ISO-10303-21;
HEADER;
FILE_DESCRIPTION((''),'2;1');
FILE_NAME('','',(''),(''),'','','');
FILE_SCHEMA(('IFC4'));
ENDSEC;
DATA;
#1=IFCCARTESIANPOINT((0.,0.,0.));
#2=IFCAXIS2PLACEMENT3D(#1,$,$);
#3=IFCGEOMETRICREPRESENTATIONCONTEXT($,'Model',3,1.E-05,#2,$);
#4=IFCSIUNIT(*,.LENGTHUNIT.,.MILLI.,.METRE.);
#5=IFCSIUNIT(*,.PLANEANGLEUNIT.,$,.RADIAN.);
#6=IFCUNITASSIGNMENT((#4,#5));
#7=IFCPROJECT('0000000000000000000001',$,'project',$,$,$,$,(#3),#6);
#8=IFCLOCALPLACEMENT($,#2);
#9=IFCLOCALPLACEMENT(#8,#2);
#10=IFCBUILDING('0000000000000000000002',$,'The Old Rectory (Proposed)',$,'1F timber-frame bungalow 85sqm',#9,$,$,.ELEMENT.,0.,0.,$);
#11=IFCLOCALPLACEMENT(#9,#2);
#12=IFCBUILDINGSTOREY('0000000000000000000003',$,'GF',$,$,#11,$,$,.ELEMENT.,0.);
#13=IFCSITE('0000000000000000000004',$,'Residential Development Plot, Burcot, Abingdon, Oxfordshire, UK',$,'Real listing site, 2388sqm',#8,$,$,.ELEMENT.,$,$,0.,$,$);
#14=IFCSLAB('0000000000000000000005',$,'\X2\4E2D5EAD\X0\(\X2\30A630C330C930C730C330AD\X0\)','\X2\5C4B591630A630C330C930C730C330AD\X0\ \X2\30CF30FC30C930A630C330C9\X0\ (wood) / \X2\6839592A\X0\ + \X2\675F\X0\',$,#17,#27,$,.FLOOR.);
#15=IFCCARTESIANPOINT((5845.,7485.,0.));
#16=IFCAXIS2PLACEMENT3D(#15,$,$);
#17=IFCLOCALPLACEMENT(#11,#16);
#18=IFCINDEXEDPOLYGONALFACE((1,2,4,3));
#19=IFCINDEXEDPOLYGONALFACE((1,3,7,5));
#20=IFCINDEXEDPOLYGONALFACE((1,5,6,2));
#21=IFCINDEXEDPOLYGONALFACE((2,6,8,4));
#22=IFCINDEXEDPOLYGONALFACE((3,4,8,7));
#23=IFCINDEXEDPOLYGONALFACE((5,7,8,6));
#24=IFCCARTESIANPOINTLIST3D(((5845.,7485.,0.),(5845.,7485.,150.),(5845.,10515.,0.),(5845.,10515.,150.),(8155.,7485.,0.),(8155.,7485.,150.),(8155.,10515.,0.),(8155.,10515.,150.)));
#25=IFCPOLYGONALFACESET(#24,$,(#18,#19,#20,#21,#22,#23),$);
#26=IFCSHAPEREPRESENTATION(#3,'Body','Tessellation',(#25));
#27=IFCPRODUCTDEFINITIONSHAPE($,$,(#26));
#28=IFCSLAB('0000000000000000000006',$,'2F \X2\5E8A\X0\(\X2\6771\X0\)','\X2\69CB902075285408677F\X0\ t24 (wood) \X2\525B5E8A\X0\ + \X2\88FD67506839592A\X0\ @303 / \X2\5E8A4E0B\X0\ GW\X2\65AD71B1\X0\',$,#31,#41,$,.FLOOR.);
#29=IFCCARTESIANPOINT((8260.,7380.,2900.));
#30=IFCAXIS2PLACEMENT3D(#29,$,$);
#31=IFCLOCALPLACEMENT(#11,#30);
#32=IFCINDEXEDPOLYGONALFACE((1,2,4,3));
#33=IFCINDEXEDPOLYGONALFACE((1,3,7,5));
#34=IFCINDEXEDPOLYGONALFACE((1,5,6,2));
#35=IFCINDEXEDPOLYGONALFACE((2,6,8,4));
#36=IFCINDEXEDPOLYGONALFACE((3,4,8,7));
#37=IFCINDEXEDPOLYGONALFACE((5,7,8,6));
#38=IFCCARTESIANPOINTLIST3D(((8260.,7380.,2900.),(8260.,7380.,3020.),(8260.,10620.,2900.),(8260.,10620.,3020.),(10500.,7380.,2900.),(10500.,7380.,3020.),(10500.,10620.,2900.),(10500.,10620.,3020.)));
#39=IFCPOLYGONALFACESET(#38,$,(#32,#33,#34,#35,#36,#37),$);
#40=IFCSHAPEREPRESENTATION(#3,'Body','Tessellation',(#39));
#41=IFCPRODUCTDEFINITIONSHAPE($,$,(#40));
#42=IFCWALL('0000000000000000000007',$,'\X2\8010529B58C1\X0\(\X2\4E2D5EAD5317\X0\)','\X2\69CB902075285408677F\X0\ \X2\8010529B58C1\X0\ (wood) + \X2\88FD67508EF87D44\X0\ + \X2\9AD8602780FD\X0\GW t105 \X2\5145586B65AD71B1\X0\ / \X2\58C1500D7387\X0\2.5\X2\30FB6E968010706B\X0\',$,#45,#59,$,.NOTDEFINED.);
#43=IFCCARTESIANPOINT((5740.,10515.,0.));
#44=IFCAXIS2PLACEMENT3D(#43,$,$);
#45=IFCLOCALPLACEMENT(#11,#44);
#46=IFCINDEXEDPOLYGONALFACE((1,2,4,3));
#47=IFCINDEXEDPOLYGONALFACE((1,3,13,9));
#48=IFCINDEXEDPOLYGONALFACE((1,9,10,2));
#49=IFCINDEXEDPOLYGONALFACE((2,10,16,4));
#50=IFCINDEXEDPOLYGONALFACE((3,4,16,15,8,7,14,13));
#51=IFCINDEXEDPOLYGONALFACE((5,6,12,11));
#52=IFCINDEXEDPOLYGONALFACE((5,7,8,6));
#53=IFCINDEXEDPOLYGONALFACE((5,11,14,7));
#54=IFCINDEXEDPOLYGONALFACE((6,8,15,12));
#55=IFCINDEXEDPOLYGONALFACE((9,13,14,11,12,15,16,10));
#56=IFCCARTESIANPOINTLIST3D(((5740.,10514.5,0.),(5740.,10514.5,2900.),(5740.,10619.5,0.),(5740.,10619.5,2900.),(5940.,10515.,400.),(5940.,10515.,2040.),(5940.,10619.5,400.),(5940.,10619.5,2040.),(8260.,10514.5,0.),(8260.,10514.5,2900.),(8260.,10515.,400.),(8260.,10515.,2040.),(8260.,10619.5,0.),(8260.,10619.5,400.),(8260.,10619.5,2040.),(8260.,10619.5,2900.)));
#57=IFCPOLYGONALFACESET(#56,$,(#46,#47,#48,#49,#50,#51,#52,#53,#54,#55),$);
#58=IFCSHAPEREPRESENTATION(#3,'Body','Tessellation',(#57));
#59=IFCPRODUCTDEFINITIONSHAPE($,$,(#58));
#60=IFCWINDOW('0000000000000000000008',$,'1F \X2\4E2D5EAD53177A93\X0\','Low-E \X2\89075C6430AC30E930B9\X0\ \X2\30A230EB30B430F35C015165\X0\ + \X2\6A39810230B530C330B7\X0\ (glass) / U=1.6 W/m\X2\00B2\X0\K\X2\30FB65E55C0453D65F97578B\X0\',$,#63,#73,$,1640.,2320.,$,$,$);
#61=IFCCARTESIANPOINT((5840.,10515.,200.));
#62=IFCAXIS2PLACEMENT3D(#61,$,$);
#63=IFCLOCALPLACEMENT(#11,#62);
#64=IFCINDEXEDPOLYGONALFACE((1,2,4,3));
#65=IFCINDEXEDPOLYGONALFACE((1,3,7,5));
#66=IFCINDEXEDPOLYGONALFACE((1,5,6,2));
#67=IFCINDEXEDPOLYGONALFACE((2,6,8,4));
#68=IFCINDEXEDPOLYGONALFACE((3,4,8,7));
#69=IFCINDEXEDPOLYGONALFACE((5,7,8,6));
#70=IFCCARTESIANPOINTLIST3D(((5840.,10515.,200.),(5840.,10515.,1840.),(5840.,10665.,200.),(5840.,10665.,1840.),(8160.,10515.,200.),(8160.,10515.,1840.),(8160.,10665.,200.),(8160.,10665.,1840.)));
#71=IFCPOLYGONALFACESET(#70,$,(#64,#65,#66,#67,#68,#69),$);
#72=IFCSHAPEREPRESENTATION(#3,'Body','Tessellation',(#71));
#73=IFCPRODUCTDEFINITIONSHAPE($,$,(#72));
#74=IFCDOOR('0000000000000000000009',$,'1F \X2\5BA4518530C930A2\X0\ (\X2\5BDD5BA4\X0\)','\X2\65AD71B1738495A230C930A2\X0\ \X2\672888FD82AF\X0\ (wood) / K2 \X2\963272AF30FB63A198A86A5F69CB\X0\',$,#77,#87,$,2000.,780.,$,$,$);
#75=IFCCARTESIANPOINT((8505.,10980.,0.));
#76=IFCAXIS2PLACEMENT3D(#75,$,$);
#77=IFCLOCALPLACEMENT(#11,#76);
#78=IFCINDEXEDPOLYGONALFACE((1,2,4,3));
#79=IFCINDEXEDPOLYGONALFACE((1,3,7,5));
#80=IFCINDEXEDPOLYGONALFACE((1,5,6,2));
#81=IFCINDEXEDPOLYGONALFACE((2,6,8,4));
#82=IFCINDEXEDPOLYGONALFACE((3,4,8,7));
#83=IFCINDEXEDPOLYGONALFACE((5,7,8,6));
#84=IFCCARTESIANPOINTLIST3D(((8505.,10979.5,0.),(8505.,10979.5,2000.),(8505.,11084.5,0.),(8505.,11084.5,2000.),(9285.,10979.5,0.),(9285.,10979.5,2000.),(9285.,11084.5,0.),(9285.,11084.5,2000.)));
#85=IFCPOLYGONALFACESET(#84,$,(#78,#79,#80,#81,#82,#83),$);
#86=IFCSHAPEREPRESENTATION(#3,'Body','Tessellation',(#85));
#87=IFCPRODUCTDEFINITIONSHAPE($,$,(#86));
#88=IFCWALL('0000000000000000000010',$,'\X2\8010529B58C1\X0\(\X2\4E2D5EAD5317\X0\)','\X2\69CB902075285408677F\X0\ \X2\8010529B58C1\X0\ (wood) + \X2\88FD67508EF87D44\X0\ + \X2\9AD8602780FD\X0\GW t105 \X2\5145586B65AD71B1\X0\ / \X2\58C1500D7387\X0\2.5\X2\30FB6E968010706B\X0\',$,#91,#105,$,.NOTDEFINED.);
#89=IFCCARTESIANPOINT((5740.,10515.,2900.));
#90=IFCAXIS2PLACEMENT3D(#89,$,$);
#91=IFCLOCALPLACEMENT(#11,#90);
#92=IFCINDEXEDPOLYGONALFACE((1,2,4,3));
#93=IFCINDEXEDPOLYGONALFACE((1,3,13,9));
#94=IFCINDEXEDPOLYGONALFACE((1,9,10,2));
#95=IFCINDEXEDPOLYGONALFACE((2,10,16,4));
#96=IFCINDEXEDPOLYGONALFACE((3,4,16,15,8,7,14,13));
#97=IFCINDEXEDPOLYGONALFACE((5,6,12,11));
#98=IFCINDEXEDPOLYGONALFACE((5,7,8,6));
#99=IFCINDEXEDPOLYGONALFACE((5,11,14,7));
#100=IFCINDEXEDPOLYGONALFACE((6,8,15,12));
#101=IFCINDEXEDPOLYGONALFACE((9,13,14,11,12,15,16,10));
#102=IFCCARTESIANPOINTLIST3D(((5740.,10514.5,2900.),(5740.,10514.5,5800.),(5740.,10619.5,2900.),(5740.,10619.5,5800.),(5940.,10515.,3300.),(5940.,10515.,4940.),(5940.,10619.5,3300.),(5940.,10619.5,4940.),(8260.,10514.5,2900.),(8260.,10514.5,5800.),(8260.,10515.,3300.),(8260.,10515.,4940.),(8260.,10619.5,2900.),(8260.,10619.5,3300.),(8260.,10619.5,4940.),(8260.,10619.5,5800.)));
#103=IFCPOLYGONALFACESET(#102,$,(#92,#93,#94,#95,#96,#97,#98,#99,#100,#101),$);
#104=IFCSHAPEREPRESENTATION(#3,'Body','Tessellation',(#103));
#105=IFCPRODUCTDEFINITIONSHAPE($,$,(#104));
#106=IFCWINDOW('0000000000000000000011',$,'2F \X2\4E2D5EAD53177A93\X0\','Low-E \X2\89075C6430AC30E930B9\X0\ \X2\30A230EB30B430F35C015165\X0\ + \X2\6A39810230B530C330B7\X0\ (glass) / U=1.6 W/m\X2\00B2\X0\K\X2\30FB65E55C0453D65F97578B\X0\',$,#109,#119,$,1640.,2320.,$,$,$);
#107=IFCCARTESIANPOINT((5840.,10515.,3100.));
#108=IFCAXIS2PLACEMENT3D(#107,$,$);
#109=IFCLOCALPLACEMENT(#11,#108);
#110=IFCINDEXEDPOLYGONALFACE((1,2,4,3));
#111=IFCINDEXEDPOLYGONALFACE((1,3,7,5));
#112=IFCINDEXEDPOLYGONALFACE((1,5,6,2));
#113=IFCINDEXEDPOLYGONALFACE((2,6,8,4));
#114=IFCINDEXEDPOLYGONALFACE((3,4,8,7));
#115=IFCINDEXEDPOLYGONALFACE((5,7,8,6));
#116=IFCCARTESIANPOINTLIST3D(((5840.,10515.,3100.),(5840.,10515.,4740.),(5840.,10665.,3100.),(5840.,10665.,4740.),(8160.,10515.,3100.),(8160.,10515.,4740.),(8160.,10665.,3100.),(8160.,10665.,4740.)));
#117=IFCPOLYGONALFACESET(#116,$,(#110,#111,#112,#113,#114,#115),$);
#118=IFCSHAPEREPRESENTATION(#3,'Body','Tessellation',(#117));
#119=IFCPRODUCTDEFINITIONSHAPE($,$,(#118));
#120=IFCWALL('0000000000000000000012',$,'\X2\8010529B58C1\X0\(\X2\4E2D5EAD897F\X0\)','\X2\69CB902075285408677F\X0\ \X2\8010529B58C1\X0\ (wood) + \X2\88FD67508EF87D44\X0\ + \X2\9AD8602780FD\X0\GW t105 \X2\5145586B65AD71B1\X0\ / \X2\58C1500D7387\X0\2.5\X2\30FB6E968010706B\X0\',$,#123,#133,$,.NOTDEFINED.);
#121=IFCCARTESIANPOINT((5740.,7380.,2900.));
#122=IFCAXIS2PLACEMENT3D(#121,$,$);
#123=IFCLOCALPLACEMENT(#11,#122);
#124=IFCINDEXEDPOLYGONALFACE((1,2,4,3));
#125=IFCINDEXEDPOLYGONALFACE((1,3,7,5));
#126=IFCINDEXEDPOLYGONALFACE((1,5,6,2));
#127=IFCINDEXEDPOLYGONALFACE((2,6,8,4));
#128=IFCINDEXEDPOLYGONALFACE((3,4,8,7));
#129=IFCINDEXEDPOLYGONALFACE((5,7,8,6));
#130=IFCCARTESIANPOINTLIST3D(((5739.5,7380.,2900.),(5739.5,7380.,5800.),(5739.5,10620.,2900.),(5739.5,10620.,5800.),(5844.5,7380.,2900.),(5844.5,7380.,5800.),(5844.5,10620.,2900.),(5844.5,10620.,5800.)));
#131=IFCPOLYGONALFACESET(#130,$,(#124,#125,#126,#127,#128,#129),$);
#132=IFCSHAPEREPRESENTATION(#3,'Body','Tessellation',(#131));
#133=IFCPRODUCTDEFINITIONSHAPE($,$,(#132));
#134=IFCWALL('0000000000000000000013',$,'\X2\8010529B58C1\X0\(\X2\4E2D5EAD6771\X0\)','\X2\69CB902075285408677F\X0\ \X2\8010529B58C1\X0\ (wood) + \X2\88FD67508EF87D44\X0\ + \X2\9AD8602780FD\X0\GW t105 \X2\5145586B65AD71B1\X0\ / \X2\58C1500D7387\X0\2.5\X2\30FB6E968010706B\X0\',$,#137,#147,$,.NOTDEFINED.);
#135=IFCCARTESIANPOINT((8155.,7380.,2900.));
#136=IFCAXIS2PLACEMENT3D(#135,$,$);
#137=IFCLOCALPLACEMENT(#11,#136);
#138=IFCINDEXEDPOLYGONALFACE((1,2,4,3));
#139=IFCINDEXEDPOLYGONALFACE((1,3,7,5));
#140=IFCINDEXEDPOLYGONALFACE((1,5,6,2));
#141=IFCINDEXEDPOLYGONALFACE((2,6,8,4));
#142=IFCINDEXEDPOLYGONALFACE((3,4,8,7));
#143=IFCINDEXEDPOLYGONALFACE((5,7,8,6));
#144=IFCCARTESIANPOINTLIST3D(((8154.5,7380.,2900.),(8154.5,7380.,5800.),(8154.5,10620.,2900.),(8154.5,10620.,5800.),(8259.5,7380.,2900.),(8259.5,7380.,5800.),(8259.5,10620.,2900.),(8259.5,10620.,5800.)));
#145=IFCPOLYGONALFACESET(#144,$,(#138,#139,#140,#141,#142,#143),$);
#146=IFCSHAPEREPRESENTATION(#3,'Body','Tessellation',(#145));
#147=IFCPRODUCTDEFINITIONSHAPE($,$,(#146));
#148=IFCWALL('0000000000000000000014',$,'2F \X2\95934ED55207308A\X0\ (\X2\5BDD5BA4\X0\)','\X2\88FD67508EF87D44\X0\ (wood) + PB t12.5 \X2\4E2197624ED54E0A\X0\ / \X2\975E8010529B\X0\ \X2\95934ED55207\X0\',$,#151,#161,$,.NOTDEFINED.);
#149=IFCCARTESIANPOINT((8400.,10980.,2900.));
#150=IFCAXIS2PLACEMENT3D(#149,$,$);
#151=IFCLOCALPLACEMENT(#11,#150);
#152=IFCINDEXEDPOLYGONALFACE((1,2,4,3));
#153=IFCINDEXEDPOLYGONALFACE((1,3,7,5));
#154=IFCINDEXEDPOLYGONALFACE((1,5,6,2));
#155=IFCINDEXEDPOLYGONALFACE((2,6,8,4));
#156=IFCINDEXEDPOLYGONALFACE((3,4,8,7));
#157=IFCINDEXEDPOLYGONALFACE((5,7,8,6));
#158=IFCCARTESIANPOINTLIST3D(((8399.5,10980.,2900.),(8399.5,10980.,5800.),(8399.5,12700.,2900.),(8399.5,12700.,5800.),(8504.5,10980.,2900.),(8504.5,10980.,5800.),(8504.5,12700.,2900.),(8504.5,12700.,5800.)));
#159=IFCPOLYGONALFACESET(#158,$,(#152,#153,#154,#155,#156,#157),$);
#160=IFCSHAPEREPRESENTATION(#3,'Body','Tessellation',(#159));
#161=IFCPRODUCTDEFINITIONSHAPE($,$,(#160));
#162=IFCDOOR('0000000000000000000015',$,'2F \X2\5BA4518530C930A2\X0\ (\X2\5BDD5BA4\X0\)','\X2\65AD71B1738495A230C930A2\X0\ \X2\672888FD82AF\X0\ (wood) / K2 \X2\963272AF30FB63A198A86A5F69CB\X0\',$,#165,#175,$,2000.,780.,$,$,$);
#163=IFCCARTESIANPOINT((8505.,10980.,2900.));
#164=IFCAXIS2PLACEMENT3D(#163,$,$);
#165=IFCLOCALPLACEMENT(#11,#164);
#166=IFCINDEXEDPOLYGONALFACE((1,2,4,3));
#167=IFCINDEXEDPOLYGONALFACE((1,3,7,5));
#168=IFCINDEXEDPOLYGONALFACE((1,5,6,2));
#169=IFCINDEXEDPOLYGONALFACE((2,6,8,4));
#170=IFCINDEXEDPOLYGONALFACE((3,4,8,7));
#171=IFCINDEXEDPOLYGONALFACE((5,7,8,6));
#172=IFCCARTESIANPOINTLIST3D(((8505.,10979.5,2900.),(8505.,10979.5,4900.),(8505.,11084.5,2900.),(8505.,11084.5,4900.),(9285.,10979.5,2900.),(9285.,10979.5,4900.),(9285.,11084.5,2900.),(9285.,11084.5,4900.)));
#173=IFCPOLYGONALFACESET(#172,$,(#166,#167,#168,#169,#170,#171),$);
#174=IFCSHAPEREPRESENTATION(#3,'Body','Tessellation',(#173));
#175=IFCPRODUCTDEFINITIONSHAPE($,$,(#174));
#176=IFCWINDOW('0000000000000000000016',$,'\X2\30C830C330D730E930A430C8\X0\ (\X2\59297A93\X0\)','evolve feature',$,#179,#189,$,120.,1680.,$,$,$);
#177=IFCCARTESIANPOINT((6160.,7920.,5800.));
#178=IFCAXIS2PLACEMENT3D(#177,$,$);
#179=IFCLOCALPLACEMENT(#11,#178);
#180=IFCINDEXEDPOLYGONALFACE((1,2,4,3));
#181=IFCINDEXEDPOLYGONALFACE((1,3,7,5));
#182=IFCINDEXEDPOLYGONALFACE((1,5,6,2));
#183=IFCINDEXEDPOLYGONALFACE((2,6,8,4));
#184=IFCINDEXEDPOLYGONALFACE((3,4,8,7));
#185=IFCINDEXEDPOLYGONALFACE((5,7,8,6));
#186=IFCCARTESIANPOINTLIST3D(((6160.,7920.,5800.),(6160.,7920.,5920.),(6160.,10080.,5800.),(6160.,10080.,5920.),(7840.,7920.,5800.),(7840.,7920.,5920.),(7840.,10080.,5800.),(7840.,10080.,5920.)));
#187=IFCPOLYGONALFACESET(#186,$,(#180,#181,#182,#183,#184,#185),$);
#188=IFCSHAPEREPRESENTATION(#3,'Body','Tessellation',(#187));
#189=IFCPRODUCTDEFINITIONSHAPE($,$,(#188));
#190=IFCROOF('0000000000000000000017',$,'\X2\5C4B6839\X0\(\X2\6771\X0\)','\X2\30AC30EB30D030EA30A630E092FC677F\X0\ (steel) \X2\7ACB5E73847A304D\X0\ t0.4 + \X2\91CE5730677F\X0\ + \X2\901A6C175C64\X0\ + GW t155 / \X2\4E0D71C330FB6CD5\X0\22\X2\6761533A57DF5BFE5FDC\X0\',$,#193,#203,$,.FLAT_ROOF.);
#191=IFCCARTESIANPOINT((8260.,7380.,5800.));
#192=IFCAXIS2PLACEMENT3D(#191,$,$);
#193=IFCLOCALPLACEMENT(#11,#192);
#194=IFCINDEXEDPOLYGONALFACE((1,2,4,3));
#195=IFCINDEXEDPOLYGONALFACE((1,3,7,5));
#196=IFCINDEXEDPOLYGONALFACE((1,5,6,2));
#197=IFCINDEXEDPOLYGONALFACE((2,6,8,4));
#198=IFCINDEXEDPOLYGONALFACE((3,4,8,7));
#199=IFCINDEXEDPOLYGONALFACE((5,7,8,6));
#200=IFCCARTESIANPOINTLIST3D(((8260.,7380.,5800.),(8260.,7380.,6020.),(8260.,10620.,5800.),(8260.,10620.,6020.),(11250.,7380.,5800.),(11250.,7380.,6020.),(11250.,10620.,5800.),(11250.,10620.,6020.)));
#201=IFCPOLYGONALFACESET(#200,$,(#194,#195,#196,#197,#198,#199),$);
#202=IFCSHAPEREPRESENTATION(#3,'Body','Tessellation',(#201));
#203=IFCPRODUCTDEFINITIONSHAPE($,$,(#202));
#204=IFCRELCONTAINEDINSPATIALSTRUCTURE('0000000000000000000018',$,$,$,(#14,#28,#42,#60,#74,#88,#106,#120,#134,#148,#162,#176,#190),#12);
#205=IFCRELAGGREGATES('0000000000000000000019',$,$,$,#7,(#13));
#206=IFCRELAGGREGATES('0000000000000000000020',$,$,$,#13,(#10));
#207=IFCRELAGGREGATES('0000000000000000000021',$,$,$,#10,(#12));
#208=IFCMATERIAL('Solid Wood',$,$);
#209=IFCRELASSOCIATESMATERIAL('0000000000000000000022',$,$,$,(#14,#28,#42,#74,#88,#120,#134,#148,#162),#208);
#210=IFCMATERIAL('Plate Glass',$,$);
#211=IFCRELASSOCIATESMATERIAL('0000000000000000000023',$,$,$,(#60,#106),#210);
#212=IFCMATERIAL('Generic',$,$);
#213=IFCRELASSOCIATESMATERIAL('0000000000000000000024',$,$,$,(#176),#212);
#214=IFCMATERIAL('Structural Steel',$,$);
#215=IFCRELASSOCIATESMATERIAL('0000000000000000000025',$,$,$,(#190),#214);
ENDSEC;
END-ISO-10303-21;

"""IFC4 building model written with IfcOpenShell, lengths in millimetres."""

from ifc_helpers import new_model, si_unit, frame, frame_2d, origin, place, context, project, spatial, rectangle, extrude, material, element, fill, save


model = new_model("IFC4")

# Units and contexts
model_context = context("Model", 3, precision=1e-05, world=origin())
ifc_project = project(units=[si_unit("LENGTHUNIT", "METRE", prefix="MILLI"), si_unit("PLANEANGLEUNIT", "RADIAN")], contexts=[model_context])

# Site, building, storey
site_placement = place(None, origin())
site = spatial("IfcSite", under=ifc_project, at=site_placement, Name="Residential Development Plot, Burcot, Abingdon, Oxfordshire, UK", ObjectType="Real listing site, 2388sqm", CompositionType="ELEMENT", RefElevation=0.0)
building_placement = place(site_placement, origin())
building = spatial("IfcBuilding", under=site, at=building_placement, Name="The Old Rectory (Proposed)", ObjectType="1F timber-frame bungalow 85sqm", CompositionType="ELEMENT", ElevationOfRefHeight=0.0, ElevationOfTerrain=0.0)
storey_placement = place(building_placement, origin())
storey = spatial("IfcBuildingStorey", under=building, at=storey_placement, Name="GF", CompositionType="ELEMENT", Elevation=0.0)

# Slabs
ifc_material_1 = material(Name="Solid Wood")
slab_1_placement = place(storey_placement, frame((5845.0, 7485.0, 0.0)))
element("IfcSlab", 1, at=slab_1_placement, inside=storey, material=ifc_material_1, Name="中庭(ウッドデッキ)", Description="屋外ウッドデッキ ハードウッド (wood) / 根太 + 束", PredefinedType="FLOOR", context=model_context, shape_type="SweptSolid", body=[
    extrude(rectangle(XDim=2310.0, YDim=3030.0, at=frame_2d((1155.0, 1515.0))), frame((5845.0, 7485.0, 0.0)), (0.0, 0.0, 1.0), 150.0),
])
slab_2_placement = place(storey_placement, frame((8260.0, 7380.0, 2900.0)))
element("IfcSlab", 2, at=slab_2_placement, inside=storey, material=ifc_material_1, Name="2F 床(東)", Description="構造用合板 t24 (wood) 剛床 + 製材根太 @303 / 床下 GW断熱", PredefinedType="FLOOR", context=model_context, shape_type="SweptSolid", body=[
    extrude(rectangle(XDim=2240.0, YDim=3240.0, at=frame_2d((1120.0, 1620.0))), frame((8260.0, 7380.0, 2900.0)), (0.0, 0.0, 1.0), 120.0),
])

# Wall, opening, window
wall_1_placement = place(storey_placement, frame((5740.0, 10515.0, 0.0)))
wall_1 = element("IfcWall", 3, at=wall_1_placement, inside=storey, material=ifc_material_1, Name="耐力壁(中庭北)", Description="構造用合板 耐力壁 (wood) + 製材軸組 + 高性能GW t105 充填断熱 / 壁倍率2.5・準耐火", PredefinedType="NOTDEFINED", context=model_context, shape_type="SweptSolid", body=[
    extrude(rectangle(XDim=2520.0, YDim=105.0, at=frame_2d((1260.0, 52.0))), frame((5740.0, 10515.0, 0.0)), (0.0, 0.0, 1.0), 2900.0),
])
opening_1_placement = place(storey_placement, frame((5840.0, 10515.0, 200.0)))
opening_1 = element("IfcOpeningElement", 4, at=opening_1_placement, cuts=wall_1, PredefinedType="NOTDEFINED", context=model_context, shape_type="SweptSolid", body=[
    extrude(rectangle(XDim=2320.0, YDim=150.0, at=frame_2d((1160.0, 75.0))), frame((5840.0, 10515.0, 200.0)), (0.0, 0.0, 1.0), 1640.0),
])
ifc_material_2 = material(Name="Plate Glass")
window_1_placement = place(storey_placement, frame((5840.0, 10515.0, 200.0)))
window_1 = element("IfcWindow", 5, at=window_1_placement, inside=storey, material=ifc_material_2, Name="1F 中庭北窓", Description="Low-E 複層ガラス アルゴン封入 + 樹脂サッシ (glass) / U=1.6 W/m²K・日射取得型", OverallHeight=1640.0, OverallWidth=2320.0, context=model_context, shape_type="SweptSolid", body=[
    extrude(rectangle(XDim=2320.0, YDim=150.0, at=frame_2d((1160.0, 75.0))), frame((5840.0, 10515.0, 200.0)), (0.0, 0.0, 1.0), 1640.0),
])
fill(opening_1, window_1)

# Door
door_1_placement = place(storey_placement, frame((8505.0, 10980.0, 0.0)))
element("IfcDoor", 6, at=door_1_placement, inside=storey, material=ifc_material_1, Name="1F 室内ドア (寝室)", Description="断熱玄関ドア 木製芯 (wood) / K2 防犯・採風機構", OverallHeight=2000.0, OverallWidth=780.0, context=model_context, shape_type="SweptSolid", body=[
    extrude(rectangle(XDim=780.0, YDim=105.0, at=frame_2d((390.0, 52.0))), frame((8505.0, 10980.0, 0.0)), (0.0, 0.0, 1.0), 2000.0),
])

# Wall, opening, window
wall_2_placement = place(storey_placement, frame((5740.0, 10515.0, 2900.0)))
wall_2 = element("IfcWall", 7, at=wall_2_placement, inside=storey, material=ifc_material_1, Name="耐力壁(中庭北)", Description="構造用合板 耐力壁 (wood) + 製材軸組 + 高性能GW t105 充填断熱 / 壁倍率2.5・準耐火", PredefinedType="NOTDEFINED", context=model_context, shape_type="SweptSolid", body=[
    extrude(rectangle(XDim=2520.0, YDim=105.0, at=frame_2d((1260.0, 52.0))), frame((5740.0, 10515.0, 2900.0)), (0.0, 0.0, 1.0), 2900.0),
])
opening_2_placement = place(storey_placement, frame((5840.0, 10515.0, 3100.0)))
opening_2 = element("IfcOpeningElement", 8, at=opening_2_placement, cuts=wall_2, PredefinedType="NOTDEFINED", context=model_context, shape_type="SweptSolid", body=[
    extrude(rectangle(XDim=2320.0, YDim=150.0, at=frame_2d((1160.0, 75.0))), frame((5840.0, 10515.0, 3100.0)), (0.0, 0.0, 1.0), 1640.0),
])
window_2_placement = place(storey_placement, frame((5840.0, 10515.0, 3100.0)))
window_2 = element("IfcWindow", 9, at=window_2_placement, inside=storey, material=ifc_material_2, Name="2F 中庭北窓", Description="Low-E 複層ガラス アルゴン封入 + 樹脂サッシ (glass) / U=1.6 W/m²K・日射取得型", OverallHeight=1640.0, OverallWidth=2320.0, context=model_context, shape_type="SweptSolid", body=[
    extrude(rectangle(XDim=2320.0, YDim=150.0, at=frame_2d((1160.0, 75.0))), frame((5840.0, 10515.0, 3100.0)), (0.0, 0.0, 1.0), 1640.0),
])
fill(opening_2, window_2)

# Walls
wall_3_placement = place(storey_placement, frame((5740.0, 7380.0, 2900.0)))
element("IfcWall", 10, at=wall_3_placement, inside=storey, material=ifc_material_1, Name="耐力壁(中庭西)", Description="構造用合板 耐力壁 (wood) + 製材軸組 + 高性能GW t105 充填断熱 / 壁倍率2.5・準耐火", PredefinedType="NOTDEFINED", context=model_context, shape_type="SweptSolid", body=[
    extrude(rectangle(XDim=105.0, YDim=3240.0, at=frame_2d((52.0, 1620.0))), frame((5740.0, 7380.0, 2900.0)), (0.0, 0.0, 1.0), 2900.0),
])
wall_4_placement = place(storey_placement, frame((8155.0, 7380.0, 2900.0)))
element("IfcWall", 11, at=wall_4_placement, inside=storey, material=ifc_material_1, Name="耐力壁(中庭東)", Description="構造用合板 耐力壁 (wood) + 製材軸組 + 高性能GW t105 充填断熱 / 壁倍率2.5・準耐火", PredefinedType="NOTDEFINED", context=model_context, shape_type="SweptSolid", body=[
    extrude(rectangle(XDim=105.0, YDim=3240.0, at=frame_2d((52.0, 1620.0))), frame((8155.0, 7380.0, 2900.0)), (0.0, 0.0, 1.0), 2900.0),
])
wall_5_placement = place(storey_placement, frame((8400.0, 10980.0, 2900.0)))
element("IfcWall", 12, at=wall_5_placement, inside=storey, material=ifc_material_1, Name="2F 間仕切り (寝室)", Description="製材軸組 (wood) + PB t12.5 両面仕上 / 非耐力 間仕切", PredefinedType="NOTDEFINED", context=model_context, shape_type="SweptSolid", body=[
    extrude(rectangle(XDim=105.0, YDim=1720.0, at=frame_2d((52.0, 860.0))), frame((8400.0, 10980.0, 2900.0)), (0.0, 0.0, 1.0), 2900.0),
])

# Door
door_2_placement = place(storey_placement, frame((8505.0, 10980.0, 2900.0)))
element("IfcDoor", 13, at=door_2_placement, inside=storey, material=ifc_material_1, Name="2F 室内ドア (寝室)", Description="断熱玄関ドア 木製芯 (wood) / K2 防犯・採風機構", OverallHeight=2000.0, OverallWidth=780.0, context=model_context, shape_type="SweptSolid", body=[
    extrude(rectangle(XDim=780.0, YDim=105.0, at=frame_2d((390.0, 52.0))), frame((8505.0, 10980.0, 2900.0)), (0.0, 0.0, 1.0), 2000.0),
])

# Window
ifc_material_3 = material(Name="Generic")
window_3_placement = place(storey_placement, frame((6160.0, 7920.0, 5800.0)))
element("IfcWindow", 14, at=window_3_placement, inside=storey, material=ifc_material_3, Name="トップライト (天窓)", Description="evolve feature", OverallHeight=120.0, OverallWidth=1680.0, context=model_context, shape_type="SweptSolid", body=[
    extrude(rectangle(XDim=1680.0, YDim=2160.0, at=frame_2d((840.0, 1080.0))), frame((6160.0, 7920.0, 5800.0)), (0.0, 0.0, 1.0), 120.0),
])

# Roof
ifc_material_4 = material(Name="Structural Steel")
roof_placement = place(storey_placement, frame((8260.0, 7380.0, 5800.0)))
element("IfcRoof", 15, at=roof_placement, inside=storey, material=ifc_material_4, Name="屋根(東)", Description="ガルバリウム鋼板 (steel) 立平葺き t0.4 + 野地板 + 通気層 + GW t155 / 不燃・法22条区域対応", PredefinedType="FLAT_ROOF", context=model_context, shape_type="SweptSolid", body=[
    extrude(rectangle(XDim=2990.0, YDim=3240.0, at=frame_2d((1495.0, 1620.0))), frame((8260.0, 7380.0, 5800.0)), (0.0, 0.0, 1.0), 220.0),
])

save(model, "model.ifc")
